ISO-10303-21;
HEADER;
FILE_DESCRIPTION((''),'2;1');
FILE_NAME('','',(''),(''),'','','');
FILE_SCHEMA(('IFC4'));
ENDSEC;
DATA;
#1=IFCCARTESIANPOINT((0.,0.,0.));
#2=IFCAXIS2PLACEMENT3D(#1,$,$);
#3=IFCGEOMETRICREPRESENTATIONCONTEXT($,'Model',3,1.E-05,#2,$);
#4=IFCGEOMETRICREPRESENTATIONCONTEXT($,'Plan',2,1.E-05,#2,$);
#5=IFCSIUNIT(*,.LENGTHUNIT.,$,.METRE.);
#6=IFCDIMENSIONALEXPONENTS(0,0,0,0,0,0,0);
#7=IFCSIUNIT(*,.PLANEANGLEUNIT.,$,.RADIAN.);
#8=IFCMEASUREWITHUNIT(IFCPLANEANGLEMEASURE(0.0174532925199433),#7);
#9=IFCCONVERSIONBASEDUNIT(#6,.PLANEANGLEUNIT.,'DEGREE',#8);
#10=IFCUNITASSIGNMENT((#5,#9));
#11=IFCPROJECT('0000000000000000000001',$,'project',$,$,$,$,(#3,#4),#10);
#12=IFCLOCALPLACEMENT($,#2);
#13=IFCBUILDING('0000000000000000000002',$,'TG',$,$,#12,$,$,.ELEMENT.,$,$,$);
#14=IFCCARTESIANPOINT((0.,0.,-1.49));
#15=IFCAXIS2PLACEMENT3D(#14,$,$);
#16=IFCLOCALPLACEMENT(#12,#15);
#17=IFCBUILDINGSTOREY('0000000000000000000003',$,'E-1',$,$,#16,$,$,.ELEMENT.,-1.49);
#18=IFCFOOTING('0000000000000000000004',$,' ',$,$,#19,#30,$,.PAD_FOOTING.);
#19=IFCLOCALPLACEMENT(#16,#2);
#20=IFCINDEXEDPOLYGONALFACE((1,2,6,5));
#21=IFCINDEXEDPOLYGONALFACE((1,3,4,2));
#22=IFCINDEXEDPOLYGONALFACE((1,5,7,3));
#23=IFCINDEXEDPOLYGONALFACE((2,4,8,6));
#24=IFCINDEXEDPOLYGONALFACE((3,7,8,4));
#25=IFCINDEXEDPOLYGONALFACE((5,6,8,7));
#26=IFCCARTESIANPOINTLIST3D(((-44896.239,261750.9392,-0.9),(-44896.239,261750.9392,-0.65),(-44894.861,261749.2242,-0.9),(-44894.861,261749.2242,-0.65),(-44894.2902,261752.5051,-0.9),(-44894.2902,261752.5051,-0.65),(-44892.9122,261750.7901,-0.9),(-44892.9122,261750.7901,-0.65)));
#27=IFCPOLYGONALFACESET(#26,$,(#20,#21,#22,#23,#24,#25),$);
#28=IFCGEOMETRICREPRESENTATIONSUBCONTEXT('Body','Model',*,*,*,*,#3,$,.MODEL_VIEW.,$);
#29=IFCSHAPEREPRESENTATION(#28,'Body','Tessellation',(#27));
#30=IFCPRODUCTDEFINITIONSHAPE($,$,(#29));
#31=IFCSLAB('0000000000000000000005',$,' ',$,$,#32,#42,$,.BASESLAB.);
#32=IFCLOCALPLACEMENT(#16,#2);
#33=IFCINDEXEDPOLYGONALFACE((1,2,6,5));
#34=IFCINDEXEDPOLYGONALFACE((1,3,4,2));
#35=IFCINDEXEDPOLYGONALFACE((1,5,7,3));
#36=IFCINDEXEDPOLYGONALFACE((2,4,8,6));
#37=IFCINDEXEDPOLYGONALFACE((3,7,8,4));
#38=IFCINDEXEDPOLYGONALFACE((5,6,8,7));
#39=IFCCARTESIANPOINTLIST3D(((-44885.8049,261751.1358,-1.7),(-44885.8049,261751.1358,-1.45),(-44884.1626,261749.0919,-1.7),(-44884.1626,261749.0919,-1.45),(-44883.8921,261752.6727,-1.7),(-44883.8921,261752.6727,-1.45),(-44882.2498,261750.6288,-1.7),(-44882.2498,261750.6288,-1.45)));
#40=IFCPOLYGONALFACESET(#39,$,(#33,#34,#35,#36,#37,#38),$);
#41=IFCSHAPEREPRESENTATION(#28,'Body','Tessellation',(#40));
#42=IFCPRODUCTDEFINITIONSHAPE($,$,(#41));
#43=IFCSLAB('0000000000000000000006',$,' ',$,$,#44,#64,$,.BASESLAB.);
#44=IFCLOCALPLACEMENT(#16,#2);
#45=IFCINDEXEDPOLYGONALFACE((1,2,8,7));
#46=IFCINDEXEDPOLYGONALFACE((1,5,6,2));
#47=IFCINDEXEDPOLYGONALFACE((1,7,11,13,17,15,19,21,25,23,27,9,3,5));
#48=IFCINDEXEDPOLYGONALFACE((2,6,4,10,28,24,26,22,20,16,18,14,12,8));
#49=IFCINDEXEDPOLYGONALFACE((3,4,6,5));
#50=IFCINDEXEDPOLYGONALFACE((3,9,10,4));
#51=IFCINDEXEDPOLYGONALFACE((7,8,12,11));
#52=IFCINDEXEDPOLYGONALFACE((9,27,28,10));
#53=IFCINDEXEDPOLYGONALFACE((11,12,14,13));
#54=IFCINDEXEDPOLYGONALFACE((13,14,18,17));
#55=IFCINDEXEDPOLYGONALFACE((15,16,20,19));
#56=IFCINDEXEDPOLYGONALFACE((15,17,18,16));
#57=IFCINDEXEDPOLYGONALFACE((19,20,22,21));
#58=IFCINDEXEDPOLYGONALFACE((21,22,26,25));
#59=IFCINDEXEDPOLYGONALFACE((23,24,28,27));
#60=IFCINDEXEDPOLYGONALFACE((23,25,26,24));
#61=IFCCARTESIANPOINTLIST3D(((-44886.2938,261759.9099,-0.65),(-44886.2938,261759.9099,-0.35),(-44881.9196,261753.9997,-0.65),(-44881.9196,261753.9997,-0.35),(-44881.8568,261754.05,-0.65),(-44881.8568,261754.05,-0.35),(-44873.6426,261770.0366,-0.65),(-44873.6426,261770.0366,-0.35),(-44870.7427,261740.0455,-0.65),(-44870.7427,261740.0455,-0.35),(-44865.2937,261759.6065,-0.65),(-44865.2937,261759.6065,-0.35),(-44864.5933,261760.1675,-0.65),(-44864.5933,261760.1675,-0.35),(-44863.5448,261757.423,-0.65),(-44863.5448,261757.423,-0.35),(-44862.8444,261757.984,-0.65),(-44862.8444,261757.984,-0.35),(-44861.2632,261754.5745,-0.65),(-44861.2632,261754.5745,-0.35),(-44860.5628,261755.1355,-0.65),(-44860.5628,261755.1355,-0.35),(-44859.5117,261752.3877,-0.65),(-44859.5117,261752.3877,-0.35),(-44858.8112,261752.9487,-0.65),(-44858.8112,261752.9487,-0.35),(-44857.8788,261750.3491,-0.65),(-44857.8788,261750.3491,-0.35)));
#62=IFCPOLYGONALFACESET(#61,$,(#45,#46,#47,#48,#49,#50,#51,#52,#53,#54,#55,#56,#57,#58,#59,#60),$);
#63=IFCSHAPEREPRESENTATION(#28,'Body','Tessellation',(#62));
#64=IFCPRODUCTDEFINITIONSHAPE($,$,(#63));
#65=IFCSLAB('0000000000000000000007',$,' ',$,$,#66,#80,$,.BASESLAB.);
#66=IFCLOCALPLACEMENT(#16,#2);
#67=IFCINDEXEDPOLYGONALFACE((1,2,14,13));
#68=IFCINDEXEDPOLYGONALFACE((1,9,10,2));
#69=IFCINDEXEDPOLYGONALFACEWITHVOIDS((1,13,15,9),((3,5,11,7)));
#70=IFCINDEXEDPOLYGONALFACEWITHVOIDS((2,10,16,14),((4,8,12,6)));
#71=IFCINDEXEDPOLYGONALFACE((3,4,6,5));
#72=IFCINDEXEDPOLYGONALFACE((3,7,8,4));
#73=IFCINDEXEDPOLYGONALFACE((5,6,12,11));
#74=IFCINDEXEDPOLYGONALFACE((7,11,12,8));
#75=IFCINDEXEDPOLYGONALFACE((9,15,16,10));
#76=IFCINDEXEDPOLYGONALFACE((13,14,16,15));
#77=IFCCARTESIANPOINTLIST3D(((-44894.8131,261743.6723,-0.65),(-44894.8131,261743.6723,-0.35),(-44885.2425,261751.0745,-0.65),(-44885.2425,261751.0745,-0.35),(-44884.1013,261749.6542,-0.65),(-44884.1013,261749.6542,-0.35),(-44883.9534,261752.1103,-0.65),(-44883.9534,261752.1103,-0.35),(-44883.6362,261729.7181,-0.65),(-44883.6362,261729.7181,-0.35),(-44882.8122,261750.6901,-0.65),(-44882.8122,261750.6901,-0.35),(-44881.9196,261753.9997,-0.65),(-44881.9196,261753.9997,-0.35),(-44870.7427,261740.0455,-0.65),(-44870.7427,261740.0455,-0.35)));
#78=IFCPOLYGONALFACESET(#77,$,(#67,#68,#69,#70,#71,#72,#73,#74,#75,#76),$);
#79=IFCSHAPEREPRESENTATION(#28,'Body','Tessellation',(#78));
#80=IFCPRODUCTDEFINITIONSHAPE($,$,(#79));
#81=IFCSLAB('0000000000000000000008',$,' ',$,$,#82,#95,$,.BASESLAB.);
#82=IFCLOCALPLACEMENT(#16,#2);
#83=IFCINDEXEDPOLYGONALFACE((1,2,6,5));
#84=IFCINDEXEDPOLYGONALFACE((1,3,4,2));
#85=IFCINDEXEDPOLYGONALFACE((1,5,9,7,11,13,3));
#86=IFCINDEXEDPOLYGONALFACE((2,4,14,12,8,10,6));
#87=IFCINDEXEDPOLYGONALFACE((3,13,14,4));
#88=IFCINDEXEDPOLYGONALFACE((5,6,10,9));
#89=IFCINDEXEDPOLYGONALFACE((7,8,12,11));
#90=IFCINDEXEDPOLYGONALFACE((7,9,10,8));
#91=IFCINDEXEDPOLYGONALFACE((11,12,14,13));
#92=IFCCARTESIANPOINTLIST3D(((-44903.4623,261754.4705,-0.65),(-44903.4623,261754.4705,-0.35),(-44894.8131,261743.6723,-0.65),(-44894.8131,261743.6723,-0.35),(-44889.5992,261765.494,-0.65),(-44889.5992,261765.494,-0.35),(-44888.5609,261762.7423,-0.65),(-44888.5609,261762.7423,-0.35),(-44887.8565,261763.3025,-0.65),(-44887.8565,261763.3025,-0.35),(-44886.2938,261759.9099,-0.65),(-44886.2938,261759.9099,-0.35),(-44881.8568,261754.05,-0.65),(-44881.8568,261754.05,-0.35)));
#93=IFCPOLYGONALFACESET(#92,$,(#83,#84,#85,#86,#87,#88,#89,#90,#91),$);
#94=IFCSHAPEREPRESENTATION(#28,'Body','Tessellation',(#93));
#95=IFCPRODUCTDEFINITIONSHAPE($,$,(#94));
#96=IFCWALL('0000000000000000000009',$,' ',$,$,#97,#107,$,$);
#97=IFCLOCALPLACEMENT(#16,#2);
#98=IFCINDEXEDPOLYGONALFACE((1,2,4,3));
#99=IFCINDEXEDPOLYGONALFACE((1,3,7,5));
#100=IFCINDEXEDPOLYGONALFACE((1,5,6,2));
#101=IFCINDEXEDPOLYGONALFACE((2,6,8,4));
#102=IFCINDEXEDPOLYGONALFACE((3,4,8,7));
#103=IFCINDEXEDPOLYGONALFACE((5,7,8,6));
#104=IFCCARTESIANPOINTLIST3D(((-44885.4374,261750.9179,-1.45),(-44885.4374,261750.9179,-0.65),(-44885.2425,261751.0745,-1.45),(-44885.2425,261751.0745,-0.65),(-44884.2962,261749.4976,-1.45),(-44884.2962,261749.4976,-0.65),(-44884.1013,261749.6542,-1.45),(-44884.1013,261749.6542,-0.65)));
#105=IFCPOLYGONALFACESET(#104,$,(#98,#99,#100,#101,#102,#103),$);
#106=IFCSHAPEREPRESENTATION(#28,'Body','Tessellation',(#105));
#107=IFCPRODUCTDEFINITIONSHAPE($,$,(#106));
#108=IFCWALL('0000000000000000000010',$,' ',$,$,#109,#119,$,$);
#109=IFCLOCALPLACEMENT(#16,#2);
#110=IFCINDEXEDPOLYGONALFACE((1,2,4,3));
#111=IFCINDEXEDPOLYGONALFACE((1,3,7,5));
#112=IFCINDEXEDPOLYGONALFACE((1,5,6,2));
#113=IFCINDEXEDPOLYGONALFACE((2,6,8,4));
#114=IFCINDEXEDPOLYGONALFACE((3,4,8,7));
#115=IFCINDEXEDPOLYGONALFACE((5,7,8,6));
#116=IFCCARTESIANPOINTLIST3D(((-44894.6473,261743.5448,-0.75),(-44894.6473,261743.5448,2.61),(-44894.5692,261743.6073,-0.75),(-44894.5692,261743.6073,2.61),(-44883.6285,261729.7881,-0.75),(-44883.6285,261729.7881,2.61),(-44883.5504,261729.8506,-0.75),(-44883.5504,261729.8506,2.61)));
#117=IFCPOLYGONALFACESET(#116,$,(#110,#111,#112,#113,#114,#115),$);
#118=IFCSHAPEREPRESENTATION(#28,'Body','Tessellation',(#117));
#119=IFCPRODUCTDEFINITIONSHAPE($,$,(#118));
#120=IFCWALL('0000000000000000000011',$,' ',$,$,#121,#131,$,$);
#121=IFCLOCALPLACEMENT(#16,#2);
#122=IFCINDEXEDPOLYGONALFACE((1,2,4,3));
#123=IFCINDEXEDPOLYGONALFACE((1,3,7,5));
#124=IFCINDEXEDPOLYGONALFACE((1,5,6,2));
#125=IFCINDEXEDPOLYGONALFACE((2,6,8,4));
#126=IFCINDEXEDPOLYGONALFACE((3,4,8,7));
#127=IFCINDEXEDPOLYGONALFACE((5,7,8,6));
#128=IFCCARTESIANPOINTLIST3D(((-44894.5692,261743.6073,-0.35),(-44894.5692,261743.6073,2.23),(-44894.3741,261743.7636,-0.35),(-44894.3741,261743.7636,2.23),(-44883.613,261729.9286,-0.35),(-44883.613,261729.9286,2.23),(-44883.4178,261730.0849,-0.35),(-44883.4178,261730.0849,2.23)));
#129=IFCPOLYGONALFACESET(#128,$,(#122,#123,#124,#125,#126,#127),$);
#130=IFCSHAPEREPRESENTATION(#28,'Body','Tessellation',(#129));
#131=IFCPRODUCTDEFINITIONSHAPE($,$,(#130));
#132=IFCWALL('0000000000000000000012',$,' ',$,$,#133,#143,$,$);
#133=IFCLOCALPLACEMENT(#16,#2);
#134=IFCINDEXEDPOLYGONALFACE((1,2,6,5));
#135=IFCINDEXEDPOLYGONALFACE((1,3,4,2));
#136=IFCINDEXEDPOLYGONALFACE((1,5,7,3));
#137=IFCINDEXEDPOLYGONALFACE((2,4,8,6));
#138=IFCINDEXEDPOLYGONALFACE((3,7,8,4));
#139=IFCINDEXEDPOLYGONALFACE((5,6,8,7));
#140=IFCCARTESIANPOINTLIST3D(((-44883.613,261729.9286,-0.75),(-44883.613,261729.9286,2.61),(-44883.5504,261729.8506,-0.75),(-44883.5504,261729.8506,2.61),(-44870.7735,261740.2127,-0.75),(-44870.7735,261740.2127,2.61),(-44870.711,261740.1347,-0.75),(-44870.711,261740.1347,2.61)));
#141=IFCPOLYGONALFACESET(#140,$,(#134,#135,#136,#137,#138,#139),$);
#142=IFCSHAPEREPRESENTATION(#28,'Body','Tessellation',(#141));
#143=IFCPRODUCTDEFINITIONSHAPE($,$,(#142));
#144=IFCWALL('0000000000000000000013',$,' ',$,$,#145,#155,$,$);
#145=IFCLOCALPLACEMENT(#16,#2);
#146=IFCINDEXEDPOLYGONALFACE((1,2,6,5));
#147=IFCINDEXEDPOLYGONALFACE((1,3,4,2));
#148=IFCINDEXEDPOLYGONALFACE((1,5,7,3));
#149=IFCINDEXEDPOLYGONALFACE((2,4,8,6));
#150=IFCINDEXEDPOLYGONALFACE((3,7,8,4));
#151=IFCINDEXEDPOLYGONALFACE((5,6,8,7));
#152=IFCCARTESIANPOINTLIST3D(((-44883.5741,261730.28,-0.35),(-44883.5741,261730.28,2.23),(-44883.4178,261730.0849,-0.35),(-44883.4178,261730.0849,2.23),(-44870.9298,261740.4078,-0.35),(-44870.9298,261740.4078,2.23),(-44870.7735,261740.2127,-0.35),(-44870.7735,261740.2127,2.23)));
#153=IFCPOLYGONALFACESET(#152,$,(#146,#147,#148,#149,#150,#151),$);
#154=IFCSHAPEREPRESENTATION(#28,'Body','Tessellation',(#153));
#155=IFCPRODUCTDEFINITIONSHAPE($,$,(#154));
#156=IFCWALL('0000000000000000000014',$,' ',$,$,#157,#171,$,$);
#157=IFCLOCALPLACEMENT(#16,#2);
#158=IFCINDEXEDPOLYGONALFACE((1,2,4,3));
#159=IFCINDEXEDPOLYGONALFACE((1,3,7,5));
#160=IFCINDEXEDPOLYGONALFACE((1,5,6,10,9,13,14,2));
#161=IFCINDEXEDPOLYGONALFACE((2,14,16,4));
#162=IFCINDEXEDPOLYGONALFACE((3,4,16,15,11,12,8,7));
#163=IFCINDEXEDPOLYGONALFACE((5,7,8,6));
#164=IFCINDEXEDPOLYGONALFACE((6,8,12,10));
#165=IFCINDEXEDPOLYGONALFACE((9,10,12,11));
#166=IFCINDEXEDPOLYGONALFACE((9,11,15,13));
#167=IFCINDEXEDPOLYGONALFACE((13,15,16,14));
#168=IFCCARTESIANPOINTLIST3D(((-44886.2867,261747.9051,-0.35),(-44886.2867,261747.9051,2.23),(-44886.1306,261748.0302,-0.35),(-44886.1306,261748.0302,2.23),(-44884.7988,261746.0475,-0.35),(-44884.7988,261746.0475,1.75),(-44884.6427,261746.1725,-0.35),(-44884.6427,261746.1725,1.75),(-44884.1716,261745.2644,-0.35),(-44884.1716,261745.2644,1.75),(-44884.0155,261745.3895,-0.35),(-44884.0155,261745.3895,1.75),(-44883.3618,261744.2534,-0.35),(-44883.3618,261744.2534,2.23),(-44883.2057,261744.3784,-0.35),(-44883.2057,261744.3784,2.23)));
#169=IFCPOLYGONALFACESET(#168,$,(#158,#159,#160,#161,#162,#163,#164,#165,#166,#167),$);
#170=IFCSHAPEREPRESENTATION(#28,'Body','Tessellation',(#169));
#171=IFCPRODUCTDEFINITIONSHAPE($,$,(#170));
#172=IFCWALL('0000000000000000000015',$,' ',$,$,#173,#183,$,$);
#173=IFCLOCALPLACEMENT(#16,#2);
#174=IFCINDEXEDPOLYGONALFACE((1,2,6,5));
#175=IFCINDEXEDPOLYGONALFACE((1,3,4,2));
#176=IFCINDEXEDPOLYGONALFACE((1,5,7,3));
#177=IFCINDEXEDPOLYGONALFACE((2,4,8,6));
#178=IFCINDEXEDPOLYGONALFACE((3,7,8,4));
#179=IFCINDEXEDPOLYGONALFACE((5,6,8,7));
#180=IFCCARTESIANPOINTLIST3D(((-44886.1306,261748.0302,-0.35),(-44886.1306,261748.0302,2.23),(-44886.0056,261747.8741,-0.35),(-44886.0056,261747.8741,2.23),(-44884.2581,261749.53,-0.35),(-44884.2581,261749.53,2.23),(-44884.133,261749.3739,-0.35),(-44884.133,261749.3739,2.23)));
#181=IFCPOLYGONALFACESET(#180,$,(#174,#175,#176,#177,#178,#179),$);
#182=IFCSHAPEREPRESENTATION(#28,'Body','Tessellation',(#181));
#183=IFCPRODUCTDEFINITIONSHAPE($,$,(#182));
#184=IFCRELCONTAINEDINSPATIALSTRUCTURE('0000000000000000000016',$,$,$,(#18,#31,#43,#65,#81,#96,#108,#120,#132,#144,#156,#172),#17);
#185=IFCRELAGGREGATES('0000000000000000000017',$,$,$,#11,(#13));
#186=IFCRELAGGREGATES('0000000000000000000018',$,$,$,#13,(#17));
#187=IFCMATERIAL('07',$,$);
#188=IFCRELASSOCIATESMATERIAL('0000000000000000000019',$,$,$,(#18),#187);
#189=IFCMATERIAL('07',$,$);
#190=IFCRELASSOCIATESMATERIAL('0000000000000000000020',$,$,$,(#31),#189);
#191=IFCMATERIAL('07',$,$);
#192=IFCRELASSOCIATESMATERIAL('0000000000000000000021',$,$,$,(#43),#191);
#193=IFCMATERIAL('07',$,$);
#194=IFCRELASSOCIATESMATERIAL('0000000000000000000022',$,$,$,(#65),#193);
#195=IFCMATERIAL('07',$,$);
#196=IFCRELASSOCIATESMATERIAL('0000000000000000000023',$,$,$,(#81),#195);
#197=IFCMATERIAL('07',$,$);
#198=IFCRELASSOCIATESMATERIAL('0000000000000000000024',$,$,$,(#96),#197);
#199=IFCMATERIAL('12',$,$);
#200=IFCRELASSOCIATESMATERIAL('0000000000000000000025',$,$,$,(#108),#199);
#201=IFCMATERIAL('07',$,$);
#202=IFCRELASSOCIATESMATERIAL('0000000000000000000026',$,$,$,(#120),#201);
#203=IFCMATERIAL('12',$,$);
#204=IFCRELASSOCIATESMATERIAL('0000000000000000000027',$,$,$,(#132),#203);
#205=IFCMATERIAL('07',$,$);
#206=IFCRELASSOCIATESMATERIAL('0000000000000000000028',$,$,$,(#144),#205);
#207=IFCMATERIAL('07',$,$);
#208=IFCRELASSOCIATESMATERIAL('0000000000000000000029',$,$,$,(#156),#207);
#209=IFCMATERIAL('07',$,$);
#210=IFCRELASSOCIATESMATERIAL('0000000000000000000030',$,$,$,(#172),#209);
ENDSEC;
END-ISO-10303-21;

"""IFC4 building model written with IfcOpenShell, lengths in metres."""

from ifc_helpers import new_model, entity, si_unit, converted_unit, frame, frame_2d, origin, origin_with_axes, place, context, subcontext, project, spatial, polyline, rectangle, outline, extrude, material, element, save


model = new_model("IFC4")

# Units and contexts
model_context = context("Model", 3, precision=1e-05, world=origin())
plan_context = context("Plan", 2, precision=1e-05, world=origin())
body_context = subcontext(model_context, "Body", "Model", "MODEL_VIEW")
ifc_project = project(units=[si_unit("LENGTHUNIT", "METRE"), converted_unit("PLANEANGLEUNIT", "DEGREE", entity("IfcPlaneAngleMeasure", 0.0174532925199433), si_unit("PLANEANGLEUNIT", "RADIAN"), dimensions=[0, 0, 0, 0, 0, 0, 0])], contexts=[model_context, plan_context])

# Building, storey
building_placement = place(None, origin())
building = spatial("IfcBuilding", under=ifc_project, at=building_placement, Name="TG", CompositionType="ELEMENT")
storey_placement = place(building_placement, frame((0.0, 0.0, -1.49)))
storey = spatial("IfcBuildingStorey", under=building, at=storey_placement, Name="E-1", CompositionType="ELEMENT", Elevation=-1.49)

# Footing
ifc_material_1 = material(Name="07")
footing_placement = place(storey_placement, frame((-44896.239, 261749.2242, -0.9)))
element("IfcFooting", 1, at=footing_placement, inside=storey, material=ifc_material_1, Name=" ", PredefinedType="PAD_FOOTING", context=body_context, shape_type="SweptSolid", body=[
    extrude(rectangle(XDim=2.5, YDim=2.2, at=frame_2d((0.2854, 1.6404), x_axis=(0.779531, 0.626364))), frame((1.378, 0.0, 0.0), z_axis=(0.0, 0.0, 1.0), x_axis=(1.0, 0.0, 0.0)), (0.0, 0.0, 1.0), 0.25),
])

# Slabs
ifc_material_2 = material(Name="07")
slab_1_placement = place(storey_placement, frame((-44885.8049, 261749.0919, -1.7)))
element("IfcSlab", 2, at=slab_1_placement, inside=storey, material=ifc_material_2, Name=" ", PredefinedType="BASESLAB", context=body_context, shape_type="SweptSolid", body=[
    extrude(rectangle(XDim=2.6219, YDim=2.4538, at=frame_2d((1.7775, -0.2535), x_axis=(0.626364, -0.779531))), frame((0.0, 2.0439, 0.0), z_axis=(0.0, 0.0, 1.0), x_axis=(1.0, 0.0, 0.0)), (0.0, 0.0, 1.0), 0.25),
])
ifc_material_3 = material(Name="07")
slab_2_placement = place(storey_placement, frame((-44886.2938, 261740.0455, -0.65)))
element("IfcSlab", 3, at=slab_2_placement, inside=storey, material=ifc_material_3, Name=" ", PredefinedType="BASESLAB", context=body_context, shape_type="SweptSolid", body=[
    extrude(outline(polyline([(28.4149, 10.3036), (26.7821, 12.3422), (27.4825, 12.9032), (25.7309, 15.09), (25.0305, 14.529), (22.749, 17.3774), (23.4494, 17.9385), (21.7005, 20.1219), (21.0, 19.5609), (12.6512, 29.9911), (0.0, 19.8644), (4.4369, 14.0044), (4.3742, 13.9541), (15.5511, 0.0), (28.4149, 10.3036)])), origin_with_axes(), (0.0, 0.0, 1.0), 0.3),
])

# Slab, opening
ifc_material_4 = material(Name="07")
slab_3_placement = place(storey_placement, frame((-44894.8131, 261729.7181, -0.65)))
slab_3 = element("IfcSlab", 4, at=slab_3_placement, inside=storey, material=ifc_material_4, Name=" ", PredefinedType="BASESLAB", context=body_context, shape_type="SweptSolid", body=[
    extrude(rectangle(XDim=16.5197, YDim=17.8785, at=frame_2d((0.8583, 12.1408), x_axis=(0.780498, 0.625159))), frame((11.1769, 0.0, 0.0), z_axis=(0.0, 0.0, 1.0), x_axis=(1.0, 0.0, 0.0)), (0.0, 0.0, 1.0), 0.3),
])
opening_1_placement = place(slab_3_placement, frame((9.5706, 19.9361, 0.0)))
element("IfcOpeningStandardCase", 5, at=opening_1_placement, cuts=slab_3, PredefinedType="OPENING", context=body_context, shape_type="SweptSolid", body=[
    extrude(rectangle(XDim=1.8219, YDim=1.6538, at=frame_2d((0.0, 0.0), x_axis=(0.626364, -0.779531))), frame((1.2152, 1.2281, 0.0), z_axis=(0.0, 0.0, 1.0), x_axis=(1.0, 0.0, 0.0)), (0.0, 0.0, 1.0), 0.3),
])

# Slab
ifc_material_5 = material(Name="07")
slab_4_placement = place(storey_placement, frame((-44903.4623, 261743.6723, -0.65)))
element("IfcSlab", 6, at=slab_4_placement, inside=storey, material=ifc_material_5, Name=" ", PredefinedType="BASESLAB", context=body_context, shape_type="SweptSolid", body=[
    extrude(outline(polyline([(8.6491, 0.0), (21.6055, 10.3777), (17.1685, 16.2377), (14.9013, 19.07), (15.6058, 19.6302), (13.8631, 21.8218), (0.0, 10.7982), (8.6491, 0.0)])), origin_with_axes(), (0.0, 0.0, 1.0), 0.3),
])

# Walls
ifc_material_6 = material(Name="07")
wall_1_placement = place(storey_placement, frame((-44884.1013, 261749.6542, -1.45), z_axis=(0.0, 0.0, 1.0), x_axis=(-0.626364, 0.779531, 0.0)))
element("IfcWall", 7, at=wall_1_placement, inside=storey, material=ifc_material_6, Name=" ", context=body_context, shape_type="SweptSolid", body=[
    extrude(rectangle(XDim=1.8219, YDim=0.25, at=frame_2d((0.911, 0.125), x_axis=(1.0, 0.0))), origin_with_axes(), (0.0, 0.0, 1.0), 0.8),
])
ifc_material_7 = material(Name="12")
wall_2_placement = place(storey_placement, frame((-44894.6473, 261743.5448, -0.75), z_axis=(0.0, 0.0, 1.0), x_axis=(0.625159, -0.780498, 0.0)))
element("IfcWall", 8, at=wall_2_placement, inside=storey, material=ifc_material_7, Name=" ", context=body_context, shape_type="SweptSolid", body=[
    extrude(rectangle(XDim=17.6256, YDim=0.1, at=frame_2d((8.8128, 0.05), x_axis=(1.0, 0.0))), origin_with_axes(), (0.0, 0.0, 1.0), 3.36),
])
ifc_material_8 = material(Name="07")
wall_3_placement = place(storey_placement, frame((-44894.5692, 261743.6073, -0.35), z_axis=(0.0, 0.0, 1.0), x_axis=(0.625159, -0.780498, 0.0)))
element("IfcWall", 9, at=wall_3_placement, inside=storey, material=ifc_material_8, Name=" ", context=body_context, shape_type="SweptSolid", body=[
    extrude(rectangle(XDim=17.5256, YDim=0.25, at=frame_2d((8.7628, 0.125), x_axis=(1.0, 0.0))), origin_with_axes(), (0.0, 0.0, 1.0), 2.58),
])
ifc_material_9 = material(Name="12")
wall_4_placement = place(storey_placement, frame((-44883.5504, 261729.8506, -0.75), z_axis=(0.0, 0.0, 1.0), x_axis=(0.780498, 0.625159, 0.0)))
element("IfcWall", 10, at=wall_4_placement, inside=storey, material=ifc_material_9, Name=" ", context=body_context, shape_type="SweptSolid", body=[
    extrude(rectangle(XDim=16.4503, YDim=0.1, at=frame_2d((8.2252, 0.05), x_axis=(1.0, 0.0))), origin_with_axes(), (0.0, 0.0, 1.0), 3.36),
])
ifc_material_10 = material(Name="07")
wall_5_placement = place(storey_placement, frame((-44883.4178, 261730.0849, -0.35), z_axis=(0.0, 0.0, 1.0), x_axis=(0.780498, 0.625159, 0.0)))
element("IfcWall", 11, at=wall_5_placement, inside=storey, material=ifc_material_10, Name=" ", context=body_context, shape_type="SweptSolid", body=[
    extrude(rectangle(XDim=16.2003, YDim=0.25, at=frame_2d((8.1002, 0.125), x_axis=(1.0, 0.0))), origin_with_axes(), (0.0, 0.0, 1.0), 2.58),
])

# Wall, opening
ifc_material_11 = material(Name="07")
wall_6_placement = place(storey_placement, frame((-44883.2057, 261744.3784, -0.35), z_axis=(0.0, 0.0, 1.0), x_axis=(-0.625159, 0.780498, 0.0)))
wall_6 = element("IfcWall", 12, at=wall_6_placement, inside=storey, material=ifc_material_11, Name=" ", context=body_context, shape_type="SweptSolid", body=[
    extrude(rectangle(XDim=4.6787, YDim=0.2, at=frame_2d((2.3393, 0.1), x_axis=(1.0, 0.0))), origin_with_axes(), (0.0, 0.0, 1.0), 2.58),
])
opening_2_placement = place(wall_6_placement, frame((1.2953, 0.0, 0.0), z_axis=(0.0, 1.0, 0.0), x_axis=(0.0, 0.0, 1.0)))
element("IfcOpeningElement", 13, at=opening_2_placement, cuts=wall_6, ObjectType="Opening", context=body_context, shape_type="SweptSolid", body=[
    extrude(outline(polyline([(0.0, 1.0033), (2.1, 1.0033), (2.1, 0.0), (0.0, 0.0), (0.0, 1.0033)])), origin_with_axes(), (0.0, 0.0, 1.0), 0.2),
])

# Wall
ifc_material_12 = material(Name="07")
wall_7_placement = place(storey_placement, frame((-44886.0056, 261747.8741, -0.35), z_axis=(0.0, 0.0, 1.0), x_axis=(0.780498, 0.625159, 0.0)))
element("IfcWall", 14, at=wall_7_placement, inside=storey, material=ifc_material_12, Name=" ", context=body_context, shape_type="SweptSolid", body=[
    extrude(rectangle(XDim=2.3992, YDim=0.2, at=frame_2d((1.1996, 0.1), x_axis=(1.0, 0.0))), origin_with_axes(), (0.0, 0.0, 1.0), 2.58),
])

save(model, "model.ifc")
